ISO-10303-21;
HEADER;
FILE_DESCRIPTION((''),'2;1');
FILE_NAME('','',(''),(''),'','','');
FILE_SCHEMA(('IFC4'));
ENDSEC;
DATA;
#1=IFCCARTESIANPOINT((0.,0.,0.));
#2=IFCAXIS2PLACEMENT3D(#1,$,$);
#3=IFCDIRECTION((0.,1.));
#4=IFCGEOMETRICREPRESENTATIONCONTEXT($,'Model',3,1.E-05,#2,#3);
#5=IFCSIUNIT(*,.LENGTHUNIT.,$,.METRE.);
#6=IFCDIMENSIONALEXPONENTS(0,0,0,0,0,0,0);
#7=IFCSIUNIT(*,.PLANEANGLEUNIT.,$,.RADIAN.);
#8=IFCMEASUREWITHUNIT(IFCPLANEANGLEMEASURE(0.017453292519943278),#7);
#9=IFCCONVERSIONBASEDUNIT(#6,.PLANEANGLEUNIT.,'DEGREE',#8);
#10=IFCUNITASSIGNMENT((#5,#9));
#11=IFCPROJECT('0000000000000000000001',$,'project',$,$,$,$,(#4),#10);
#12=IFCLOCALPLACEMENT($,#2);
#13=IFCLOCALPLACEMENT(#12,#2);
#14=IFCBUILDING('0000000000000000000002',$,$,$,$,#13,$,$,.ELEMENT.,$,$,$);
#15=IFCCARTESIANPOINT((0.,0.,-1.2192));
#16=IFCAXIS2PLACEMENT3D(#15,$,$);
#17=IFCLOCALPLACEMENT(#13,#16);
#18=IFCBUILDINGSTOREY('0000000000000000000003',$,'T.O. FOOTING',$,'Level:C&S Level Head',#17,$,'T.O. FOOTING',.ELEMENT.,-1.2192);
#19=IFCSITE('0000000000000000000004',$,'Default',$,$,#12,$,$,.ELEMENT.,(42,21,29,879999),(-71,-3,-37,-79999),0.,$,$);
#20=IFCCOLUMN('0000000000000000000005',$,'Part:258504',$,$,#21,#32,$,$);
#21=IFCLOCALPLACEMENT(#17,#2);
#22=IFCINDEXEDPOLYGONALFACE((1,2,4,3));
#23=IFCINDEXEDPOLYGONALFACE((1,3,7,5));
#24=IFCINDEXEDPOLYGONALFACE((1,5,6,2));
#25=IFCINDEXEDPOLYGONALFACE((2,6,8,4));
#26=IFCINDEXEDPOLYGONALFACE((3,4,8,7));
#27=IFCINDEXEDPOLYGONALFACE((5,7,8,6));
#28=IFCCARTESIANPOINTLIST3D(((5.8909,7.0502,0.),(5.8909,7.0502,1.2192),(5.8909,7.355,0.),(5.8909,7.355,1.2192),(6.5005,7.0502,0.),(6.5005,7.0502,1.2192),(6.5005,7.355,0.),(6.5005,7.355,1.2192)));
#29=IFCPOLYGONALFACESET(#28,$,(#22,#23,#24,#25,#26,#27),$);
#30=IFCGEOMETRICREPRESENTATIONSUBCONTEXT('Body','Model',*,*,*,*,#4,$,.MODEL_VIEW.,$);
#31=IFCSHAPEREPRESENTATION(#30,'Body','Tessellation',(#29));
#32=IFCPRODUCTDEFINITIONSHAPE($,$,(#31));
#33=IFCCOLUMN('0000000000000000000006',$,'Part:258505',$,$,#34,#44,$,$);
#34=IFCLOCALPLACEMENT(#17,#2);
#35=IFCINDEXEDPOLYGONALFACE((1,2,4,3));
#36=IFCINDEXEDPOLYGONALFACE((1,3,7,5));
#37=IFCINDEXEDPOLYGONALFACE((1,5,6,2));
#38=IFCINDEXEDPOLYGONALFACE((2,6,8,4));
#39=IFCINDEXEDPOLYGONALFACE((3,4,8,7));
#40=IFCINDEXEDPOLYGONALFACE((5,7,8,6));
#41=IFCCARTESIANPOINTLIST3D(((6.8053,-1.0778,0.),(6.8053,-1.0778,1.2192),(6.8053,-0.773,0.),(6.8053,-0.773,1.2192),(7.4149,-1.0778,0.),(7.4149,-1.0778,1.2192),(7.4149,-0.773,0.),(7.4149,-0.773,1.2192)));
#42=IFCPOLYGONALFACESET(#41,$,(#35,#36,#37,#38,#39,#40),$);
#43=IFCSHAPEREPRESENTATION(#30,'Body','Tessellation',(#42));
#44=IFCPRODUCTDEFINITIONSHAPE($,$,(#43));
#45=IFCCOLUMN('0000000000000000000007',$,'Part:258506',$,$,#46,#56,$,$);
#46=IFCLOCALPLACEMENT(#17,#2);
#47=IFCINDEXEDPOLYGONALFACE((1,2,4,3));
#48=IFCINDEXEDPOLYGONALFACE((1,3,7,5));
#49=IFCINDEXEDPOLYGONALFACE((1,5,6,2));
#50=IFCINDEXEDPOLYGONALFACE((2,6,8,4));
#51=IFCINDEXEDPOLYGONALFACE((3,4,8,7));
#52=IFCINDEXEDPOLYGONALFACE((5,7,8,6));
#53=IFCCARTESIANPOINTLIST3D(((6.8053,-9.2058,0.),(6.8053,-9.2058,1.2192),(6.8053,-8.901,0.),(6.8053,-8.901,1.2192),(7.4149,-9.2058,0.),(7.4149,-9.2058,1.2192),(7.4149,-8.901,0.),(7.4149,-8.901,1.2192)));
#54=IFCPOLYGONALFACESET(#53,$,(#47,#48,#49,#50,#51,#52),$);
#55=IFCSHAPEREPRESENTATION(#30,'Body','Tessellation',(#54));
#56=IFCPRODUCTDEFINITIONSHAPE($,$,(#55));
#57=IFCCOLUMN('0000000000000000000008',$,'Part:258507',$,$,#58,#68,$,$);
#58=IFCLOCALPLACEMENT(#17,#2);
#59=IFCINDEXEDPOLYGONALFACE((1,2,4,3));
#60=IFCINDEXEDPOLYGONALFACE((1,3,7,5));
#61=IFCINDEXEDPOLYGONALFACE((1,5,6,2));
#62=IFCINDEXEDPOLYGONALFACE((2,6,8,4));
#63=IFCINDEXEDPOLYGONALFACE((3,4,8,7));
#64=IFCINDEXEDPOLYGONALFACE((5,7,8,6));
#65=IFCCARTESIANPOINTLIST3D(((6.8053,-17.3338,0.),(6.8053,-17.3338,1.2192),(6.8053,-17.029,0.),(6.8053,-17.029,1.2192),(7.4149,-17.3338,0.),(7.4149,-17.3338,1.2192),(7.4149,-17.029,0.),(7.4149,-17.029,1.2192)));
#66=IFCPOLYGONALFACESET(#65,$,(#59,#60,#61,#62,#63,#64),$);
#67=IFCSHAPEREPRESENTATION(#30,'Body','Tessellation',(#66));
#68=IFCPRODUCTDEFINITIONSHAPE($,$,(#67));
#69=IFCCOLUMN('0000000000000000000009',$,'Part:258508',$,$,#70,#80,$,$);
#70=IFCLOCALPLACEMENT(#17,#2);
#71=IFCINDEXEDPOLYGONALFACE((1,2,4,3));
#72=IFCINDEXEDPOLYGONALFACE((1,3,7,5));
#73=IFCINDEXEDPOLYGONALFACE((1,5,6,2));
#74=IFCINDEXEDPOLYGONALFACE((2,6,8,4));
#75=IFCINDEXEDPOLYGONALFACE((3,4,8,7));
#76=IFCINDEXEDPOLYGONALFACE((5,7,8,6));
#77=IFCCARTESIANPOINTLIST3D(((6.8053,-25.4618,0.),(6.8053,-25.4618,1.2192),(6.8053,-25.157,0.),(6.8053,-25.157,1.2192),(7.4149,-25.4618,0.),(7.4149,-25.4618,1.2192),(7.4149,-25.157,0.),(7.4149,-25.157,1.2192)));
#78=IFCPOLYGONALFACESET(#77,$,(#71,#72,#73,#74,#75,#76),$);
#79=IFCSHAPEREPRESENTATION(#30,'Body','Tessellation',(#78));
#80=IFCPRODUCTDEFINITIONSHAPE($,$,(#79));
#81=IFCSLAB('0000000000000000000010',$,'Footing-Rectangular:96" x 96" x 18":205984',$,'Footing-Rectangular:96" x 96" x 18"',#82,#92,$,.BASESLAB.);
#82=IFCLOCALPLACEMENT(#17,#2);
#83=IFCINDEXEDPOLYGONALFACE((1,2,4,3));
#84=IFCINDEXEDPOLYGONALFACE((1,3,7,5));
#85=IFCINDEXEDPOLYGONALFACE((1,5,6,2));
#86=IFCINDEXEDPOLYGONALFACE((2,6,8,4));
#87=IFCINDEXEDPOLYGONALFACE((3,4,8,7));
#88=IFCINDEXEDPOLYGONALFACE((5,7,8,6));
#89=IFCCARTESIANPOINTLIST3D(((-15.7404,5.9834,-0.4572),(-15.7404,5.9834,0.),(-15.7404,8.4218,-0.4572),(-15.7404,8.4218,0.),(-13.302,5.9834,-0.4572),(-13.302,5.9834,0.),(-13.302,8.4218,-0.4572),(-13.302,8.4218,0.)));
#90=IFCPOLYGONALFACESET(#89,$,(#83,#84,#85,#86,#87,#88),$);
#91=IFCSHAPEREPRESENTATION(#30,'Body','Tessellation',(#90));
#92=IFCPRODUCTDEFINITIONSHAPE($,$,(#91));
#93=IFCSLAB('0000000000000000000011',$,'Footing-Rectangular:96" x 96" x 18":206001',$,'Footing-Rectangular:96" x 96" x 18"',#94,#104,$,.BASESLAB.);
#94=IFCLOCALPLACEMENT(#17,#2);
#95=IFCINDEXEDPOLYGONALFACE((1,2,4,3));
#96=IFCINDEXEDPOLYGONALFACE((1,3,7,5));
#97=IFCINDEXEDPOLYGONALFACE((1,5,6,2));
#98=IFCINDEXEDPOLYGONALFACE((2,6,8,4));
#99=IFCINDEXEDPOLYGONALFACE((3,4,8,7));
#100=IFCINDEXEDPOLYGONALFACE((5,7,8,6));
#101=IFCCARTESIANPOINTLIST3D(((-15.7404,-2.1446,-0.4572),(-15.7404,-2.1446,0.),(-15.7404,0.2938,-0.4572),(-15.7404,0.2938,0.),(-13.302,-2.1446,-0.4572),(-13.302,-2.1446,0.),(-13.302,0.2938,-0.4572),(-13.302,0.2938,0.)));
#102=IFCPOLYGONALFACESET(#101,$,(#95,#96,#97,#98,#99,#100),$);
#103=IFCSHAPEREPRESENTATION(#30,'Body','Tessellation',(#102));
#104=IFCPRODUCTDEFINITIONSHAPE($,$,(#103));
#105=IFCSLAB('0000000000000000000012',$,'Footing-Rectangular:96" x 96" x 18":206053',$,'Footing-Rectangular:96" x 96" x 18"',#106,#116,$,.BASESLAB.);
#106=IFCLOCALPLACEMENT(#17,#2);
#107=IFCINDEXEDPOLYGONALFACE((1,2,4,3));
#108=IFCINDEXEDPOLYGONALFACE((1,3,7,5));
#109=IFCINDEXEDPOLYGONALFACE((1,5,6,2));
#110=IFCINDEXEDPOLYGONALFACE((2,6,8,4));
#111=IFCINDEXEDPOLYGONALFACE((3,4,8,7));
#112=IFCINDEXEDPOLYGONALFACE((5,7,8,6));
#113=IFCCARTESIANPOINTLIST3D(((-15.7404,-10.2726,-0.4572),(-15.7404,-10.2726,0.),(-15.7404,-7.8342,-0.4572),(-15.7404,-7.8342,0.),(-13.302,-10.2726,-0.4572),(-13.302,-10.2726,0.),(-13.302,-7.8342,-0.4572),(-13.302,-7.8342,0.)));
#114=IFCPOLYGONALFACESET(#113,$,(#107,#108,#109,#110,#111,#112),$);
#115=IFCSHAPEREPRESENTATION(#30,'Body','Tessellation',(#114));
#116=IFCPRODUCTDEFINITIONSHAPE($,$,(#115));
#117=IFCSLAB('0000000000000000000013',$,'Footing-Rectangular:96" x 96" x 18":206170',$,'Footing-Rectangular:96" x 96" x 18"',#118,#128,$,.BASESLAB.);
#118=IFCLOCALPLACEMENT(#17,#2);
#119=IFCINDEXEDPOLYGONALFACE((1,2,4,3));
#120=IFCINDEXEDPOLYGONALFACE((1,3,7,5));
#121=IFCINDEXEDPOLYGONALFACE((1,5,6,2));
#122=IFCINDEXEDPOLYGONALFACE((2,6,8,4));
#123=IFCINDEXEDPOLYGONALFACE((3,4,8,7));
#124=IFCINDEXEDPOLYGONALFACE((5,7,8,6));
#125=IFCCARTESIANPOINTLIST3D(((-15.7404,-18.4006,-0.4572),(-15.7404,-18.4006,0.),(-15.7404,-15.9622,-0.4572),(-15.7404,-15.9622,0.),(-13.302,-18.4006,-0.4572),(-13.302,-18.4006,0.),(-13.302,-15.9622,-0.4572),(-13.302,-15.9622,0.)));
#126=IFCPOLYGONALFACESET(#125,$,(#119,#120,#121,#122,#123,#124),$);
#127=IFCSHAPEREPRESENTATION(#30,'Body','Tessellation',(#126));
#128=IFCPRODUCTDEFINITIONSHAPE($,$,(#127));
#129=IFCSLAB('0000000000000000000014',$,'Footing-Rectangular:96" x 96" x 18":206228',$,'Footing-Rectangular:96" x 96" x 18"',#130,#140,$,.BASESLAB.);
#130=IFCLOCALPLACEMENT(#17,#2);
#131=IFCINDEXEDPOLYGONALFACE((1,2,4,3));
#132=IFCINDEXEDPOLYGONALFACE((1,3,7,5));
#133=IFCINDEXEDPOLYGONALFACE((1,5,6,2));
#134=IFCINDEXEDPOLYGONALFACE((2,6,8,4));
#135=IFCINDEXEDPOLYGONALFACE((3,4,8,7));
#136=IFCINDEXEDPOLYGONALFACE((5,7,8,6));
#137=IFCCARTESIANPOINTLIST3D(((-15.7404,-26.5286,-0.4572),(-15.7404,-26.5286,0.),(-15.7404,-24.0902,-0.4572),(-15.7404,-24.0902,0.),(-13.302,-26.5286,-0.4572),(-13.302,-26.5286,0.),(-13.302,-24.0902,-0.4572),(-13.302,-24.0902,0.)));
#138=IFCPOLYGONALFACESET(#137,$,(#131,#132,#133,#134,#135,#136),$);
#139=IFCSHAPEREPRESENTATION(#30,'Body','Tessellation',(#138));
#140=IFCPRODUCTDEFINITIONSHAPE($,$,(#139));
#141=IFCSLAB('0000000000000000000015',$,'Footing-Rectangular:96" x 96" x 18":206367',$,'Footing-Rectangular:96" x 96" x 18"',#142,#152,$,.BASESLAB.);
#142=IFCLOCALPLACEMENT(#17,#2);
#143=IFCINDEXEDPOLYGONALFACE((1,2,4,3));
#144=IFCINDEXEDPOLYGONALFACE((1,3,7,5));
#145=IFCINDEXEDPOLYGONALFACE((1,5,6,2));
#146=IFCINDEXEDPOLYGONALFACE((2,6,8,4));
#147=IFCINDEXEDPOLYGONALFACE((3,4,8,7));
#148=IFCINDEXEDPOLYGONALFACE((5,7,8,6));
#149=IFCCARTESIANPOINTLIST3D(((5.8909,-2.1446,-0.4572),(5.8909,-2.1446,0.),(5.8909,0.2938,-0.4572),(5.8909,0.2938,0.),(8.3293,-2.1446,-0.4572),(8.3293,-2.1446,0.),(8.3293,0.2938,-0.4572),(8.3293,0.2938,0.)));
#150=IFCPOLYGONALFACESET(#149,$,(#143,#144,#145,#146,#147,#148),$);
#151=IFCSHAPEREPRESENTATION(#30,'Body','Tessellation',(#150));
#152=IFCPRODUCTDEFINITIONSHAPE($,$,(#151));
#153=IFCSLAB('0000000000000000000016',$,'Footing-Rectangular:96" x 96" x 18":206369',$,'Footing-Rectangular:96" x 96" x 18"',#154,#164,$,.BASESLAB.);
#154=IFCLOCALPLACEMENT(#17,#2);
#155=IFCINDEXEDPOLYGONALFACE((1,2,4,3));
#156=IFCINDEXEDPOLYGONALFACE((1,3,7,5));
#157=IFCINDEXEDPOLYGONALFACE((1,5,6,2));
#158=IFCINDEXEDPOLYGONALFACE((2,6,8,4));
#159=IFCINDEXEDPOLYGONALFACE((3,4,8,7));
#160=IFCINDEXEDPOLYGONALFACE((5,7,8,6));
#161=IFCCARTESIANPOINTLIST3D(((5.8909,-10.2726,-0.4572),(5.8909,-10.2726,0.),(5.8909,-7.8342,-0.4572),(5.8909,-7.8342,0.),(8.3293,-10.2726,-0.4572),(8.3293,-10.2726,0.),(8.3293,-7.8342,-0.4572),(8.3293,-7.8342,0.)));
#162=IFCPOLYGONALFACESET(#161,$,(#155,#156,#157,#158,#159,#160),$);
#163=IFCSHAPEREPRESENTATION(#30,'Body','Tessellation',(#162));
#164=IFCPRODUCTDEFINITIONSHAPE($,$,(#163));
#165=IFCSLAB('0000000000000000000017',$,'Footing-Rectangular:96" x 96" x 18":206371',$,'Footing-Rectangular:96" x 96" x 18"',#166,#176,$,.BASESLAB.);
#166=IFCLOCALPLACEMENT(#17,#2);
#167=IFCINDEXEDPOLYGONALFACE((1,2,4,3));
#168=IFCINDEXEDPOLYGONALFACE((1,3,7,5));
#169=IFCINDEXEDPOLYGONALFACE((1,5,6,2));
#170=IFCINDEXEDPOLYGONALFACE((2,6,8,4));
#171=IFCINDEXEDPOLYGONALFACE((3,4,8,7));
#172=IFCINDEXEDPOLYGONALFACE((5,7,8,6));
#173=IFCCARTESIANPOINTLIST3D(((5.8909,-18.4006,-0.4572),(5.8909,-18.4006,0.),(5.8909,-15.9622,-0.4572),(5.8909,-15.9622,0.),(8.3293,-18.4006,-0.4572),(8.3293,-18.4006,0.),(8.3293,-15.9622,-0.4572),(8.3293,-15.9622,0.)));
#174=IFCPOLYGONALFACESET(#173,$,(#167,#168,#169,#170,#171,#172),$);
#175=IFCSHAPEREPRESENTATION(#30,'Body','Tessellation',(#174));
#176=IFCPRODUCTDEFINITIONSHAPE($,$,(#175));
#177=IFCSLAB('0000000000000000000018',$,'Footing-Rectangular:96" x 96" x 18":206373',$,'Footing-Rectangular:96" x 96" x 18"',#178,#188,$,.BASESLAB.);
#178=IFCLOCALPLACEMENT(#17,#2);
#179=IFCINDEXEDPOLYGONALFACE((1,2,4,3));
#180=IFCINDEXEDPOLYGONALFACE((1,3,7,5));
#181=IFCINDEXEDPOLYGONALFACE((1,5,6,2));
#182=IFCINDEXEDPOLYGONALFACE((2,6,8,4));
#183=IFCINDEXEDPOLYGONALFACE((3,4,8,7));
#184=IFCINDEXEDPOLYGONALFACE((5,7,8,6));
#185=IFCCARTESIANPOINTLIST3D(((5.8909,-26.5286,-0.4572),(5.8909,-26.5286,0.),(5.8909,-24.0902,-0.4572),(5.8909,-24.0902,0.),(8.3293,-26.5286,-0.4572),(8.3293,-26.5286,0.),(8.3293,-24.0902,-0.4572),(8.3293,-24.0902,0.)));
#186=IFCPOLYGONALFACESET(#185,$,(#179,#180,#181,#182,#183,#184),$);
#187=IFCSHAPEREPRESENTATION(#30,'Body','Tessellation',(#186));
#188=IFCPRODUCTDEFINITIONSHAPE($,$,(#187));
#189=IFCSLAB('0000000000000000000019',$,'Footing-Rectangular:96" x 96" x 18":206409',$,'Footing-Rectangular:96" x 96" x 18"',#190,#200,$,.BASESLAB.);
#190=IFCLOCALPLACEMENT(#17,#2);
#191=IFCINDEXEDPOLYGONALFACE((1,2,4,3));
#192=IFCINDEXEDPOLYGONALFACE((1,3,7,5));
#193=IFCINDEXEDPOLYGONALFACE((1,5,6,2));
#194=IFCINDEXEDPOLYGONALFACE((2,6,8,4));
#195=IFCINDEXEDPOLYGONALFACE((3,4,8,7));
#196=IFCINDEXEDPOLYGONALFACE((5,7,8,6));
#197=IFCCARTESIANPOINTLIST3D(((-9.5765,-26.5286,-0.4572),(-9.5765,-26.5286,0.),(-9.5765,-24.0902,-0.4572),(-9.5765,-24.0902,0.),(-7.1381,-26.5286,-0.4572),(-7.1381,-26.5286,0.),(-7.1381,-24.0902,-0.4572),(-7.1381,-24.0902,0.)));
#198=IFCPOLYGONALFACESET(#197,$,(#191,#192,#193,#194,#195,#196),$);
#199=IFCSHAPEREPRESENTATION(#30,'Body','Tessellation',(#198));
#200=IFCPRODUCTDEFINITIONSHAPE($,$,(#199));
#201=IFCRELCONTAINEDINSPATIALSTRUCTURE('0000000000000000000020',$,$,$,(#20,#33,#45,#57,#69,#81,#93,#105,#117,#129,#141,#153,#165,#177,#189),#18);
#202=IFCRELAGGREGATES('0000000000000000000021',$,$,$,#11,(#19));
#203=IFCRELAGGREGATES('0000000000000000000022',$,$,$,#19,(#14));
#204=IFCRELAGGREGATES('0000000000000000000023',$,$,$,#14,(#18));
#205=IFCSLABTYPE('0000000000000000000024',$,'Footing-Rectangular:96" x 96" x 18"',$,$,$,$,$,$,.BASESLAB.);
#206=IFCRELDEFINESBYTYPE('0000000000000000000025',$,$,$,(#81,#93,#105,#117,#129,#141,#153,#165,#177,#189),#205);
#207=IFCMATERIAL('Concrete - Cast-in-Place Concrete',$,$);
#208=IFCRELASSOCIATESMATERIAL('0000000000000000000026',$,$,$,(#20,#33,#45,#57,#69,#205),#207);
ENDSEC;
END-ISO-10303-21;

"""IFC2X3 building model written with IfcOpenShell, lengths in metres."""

from ifc_helpers import new_model, entity, si_unit, converted_unit, direction, frame, frame_2d, origin, origin_2d_with_axis, place, context, subcontext, project, spatial, rectangle, extrude, material, type_object, element, save


model = new_model("IFC2X3")

# Units and contexts
model_context = context("Model", 3, precision=1e-05, world=origin(), true_north=direction((0.0, 1.0)))
body_context = subcontext(model_context, "Body", "Model", "MODEL_VIEW")
ifc_project = project(units=[si_unit("LENGTHUNIT", "METRE"), converted_unit("PLANEANGLEUNIT", "DEGREE", entity("IfcPlaneAngleMeasure", 0.017453292519943278), si_unit("PLANEANGLEUNIT", "RADIAN"), dimensions=[0, 0, 0, 0, 0, 0, 0])], contexts=[model_context])

# Site, building, storey
site_placement = place(None, origin())
site = spatial("IfcSite", under=ifc_project, at=site_placement, Name="Default", CompositionType="ELEMENT", RefLatitude=(42, 21, 29, 879999), RefLongitude=(-71, -3, -37, -79999), RefElevation=0.0)
building_placement = place(site_placement, origin())
building = spatial("IfcBuilding", under=site, at=building_placement, CompositionType="ELEMENT")
storey_placement = place(building_placement, frame((0.0, 0.0, -1.2192)))
storey = spatial("IfcBuildingStorey", under=building, at=storey_placement, Name="T.O. FOOTING", ObjectType="Level:C&S Level Head", LongName="T.O. FOOTING", CompositionType="ELEMENT", Elevation=-1.2192)

# Columns
ifc_material = material(Name="Concrete - Cast-in-Place Concrete")
column_1_placement = place(storey_placement, origin())
element("IfcColumn", 1, at=column_1_placement, inside=storey, material=ifc_material, Name="Part:258504", context=body_context, shape_type="SweptSolid", body=[
    extrude(rectangle(XDim=1.2192, YDim=0.3048, at=origin_2d_with_axis()), frame((5.8909, 7.2026, 0.6096), z_axis=(1.0, 0.0, 0.0), x_axis=(0.0, 0.0, -1.0)), (0.0, 0.0, 1.0), 0.6096),
])
column_2_placement = place(storey_placement, origin())
element("IfcColumn", 2, at=column_2_placement, inside=storey, material=ifc_material, Name="Part:258505", context=body_context, shape_type="SweptSolid", body=[
    extrude(rectangle(XDim=1.2192, YDim=0.3048, at=origin_2d_with_axis()), frame((6.8053, -0.9254, 0.6096), z_axis=(1.0, 0.0, 0.0), x_axis=(0.0, 0.0, -1.0)), (0.0, 0.0, 1.0), 0.6096),
])
column_3_placement = place(storey_placement, origin())
element("IfcColumn", 3, at=column_3_placement, inside=storey, material=ifc_material, Name="Part:258506", context=body_context, shape_type="SweptSolid", body=[
    extrude(rectangle(XDim=1.2192, YDim=0.3048, at=origin_2d_with_axis()), frame((6.8053, -9.0534, 0.6096), z_axis=(1.0, 0.0, 0.0), x_axis=(0.0, 0.0, -1.0)), (0.0, 0.0, 1.0), 0.6096),
])
column_4_placement = place(storey_placement, origin())
element("IfcColumn", 4, at=column_4_placement, inside=storey, material=ifc_material, Name="Part:258507", context=body_context, shape_type="SweptSolid", body=[
    extrude(rectangle(XDim=1.2192, YDim=0.3048, at=origin_2d_with_axis()), frame((6.8053, -17.1814, 0.6096), z_axis=(1.0, 0.0, 0.0), x_axis=(0.0, 0.0, -1.0)), (0.0, 0.0, 1.0), 0.6096),
])
column_5_placement = place(storey_placement, origin())
element("IfcColumn", 5, at=column_5_placement, inside=storey, material=ifc_material, Name="Part:258508", context=body_context, shape_type="SweptSolid", body=[
    extrude(rectangle(XDim=1.2192, YDim=0.3048, at=origin_2d_with_axis()), frame((6.8053, -25.3094, 0.6096), z_axis=(1.0, 0.0, 0.0), x_axis=(0.0, 0.0, -1.0)), (0.0, 0.0, 1.0), 0.6096),
])

# Slabs
slab_type_1 = type_object("IfcSlabType", Name="Footing-Rectangular:96\" x 96\" x 18\"", PredefinedType="BASESLAB", material=ifc_material)
slab_1_placement = place(storey_placement, origin())
element("IfcSlab", 6, at=slab_1_placement, inside=storey, type_object=slab_type_1, Name="Footing-Rectangular:96\" x 96\" x 18\":205984", ObjectType="Footing-Rectangular:96\" x 96\" x 18\"", PredefinedType="BASESLAB", context=body_context, shape_type="SweptSolid", body=[
    extrude(rectangle(XDim=2.4384, YDim=2.4384, at=origin_2d_with_axis()), frame((-14.5212, 7.2026, -0.4572), z_axis=(0.0, 0.0, 1.0), x_axis=(-1.0, 0.0, 0.0)), (0.0, 0.0, 1.0), 0.4572),
])
slab_2_placement = place(storey_placement, origin())
element("IfcSlab", 7, at=slab_2_placement, inside=storey, type_object=slab_type_1, Name="Footing-Rectangular:96\" x 96\" x 18\":206001", ObjectType="Footing-Rectangular:96\" x 96\" x 18\"", PredefinedType="BASESLAB", context=body_context, shape_type="SweptSolid", body=[
    extrude(rectangle(XDim=2.4384, YDim=2.4384, at=frame_2d((0.0, 0.0), x_axis=(1.0, 0.0))), frame((-14.5212, -0.9254, -0.4572), z_axis=(0.0, 0.0, 1.0), x_axis=(-1.0, 0.0, 0.0)), (0.0, 0.0, 1.0), 0.4572),
])
slab_3_placement = place(storey_placement, origin())
element("IfcSlab", 8, at=slab_3_placement, inside=storey, type_object=slab_type_1, Name="Footing-Rectangular:96\" x 96\" x 18\":206053", ObjectType="Footing-Rectangular:96\" x 96\" x 18\"", PredefinedType="BASESLAB", context=body_context, shape_type="SweptSolid", body=[
    extrude(rectangle(XDim=2.4384, YDim=2.4384, at=origin_2d_with_axis()), frame((-14.5212, -9.0534, -0.4572), z_axis=(0.0, 0.0, 1.0), x_axis=(-1.0, 0.0, 0.0)), (0.0, 0.0, 1.0), 0.4572),
])
slab_4_placement = place(storey_placement, origin())
element("IfcSlab", 9, at=slab_4_placement, inside=storey, type_object=slab_type_1, Name="Footing-Rectangular:96\" x 96\" x 18\":206170", ObjectType="Footing-Rectangular:96\" x 96\" x 18\"", PredefinedType="BASESLAB", context=body_context, shape_type="SweptSolid", body=[
    extrude(rectangle(XDim=2.4384, YDim=2.4384, at=origin_2d_with_axis()), frame((-14.5212, -17.1814, -0.4572), z_axis=(0.0, 0.0, 1.0), x_axis=(-1.0, 0.0, 0.0)), (0.0, 0.0, 1.0), 0.4572),
])
slab_5_placement = place(storey_placement, origin())
element("IfcSlab", 10, at=slab_5_placement, inside=storey, type_object=slab_type_1, Name="Footing-Rectangular:96\" x 96\" x 18\":206228", ObjectType="Footing-Rectangular:96\" x 96\" x 18\"", PredefinedType="BASESLAB", context=body_context, shape_type="SweptSolid", body=[
    extrude(rectangle(XDim=2.4384, YDim=2.4384, at=origin_2d_with_axis()), frame((-14.5212, -25.3094, -0.4572), z_axis=(0.0, 0.0, 1.0), x_axis=(-1.0, 0.0, 0.0)), (0.0, 0.0, 1.0), 0.4572),
])
slab_6_placement = place(storey_placement, origin())
element("IfcSlab", 11, at=slab_6_placement, inside=storey, type_object=slab_type_1, Name="Footing-Rectangular:96\" x 96\" x 18\":206367", ObjectType="Footing-Rectangular:96\" x 96\" x 18\"", PredefinedType="BASESLAB", context=body_context, shape_type="SweptSolid", body=[
    extrude(rectangle(XDim=2.4384, YDim=2.4384, at=frame_2d((0.0, 0.0), x_axis=(1.0, 0.0))), frame((7.1101, -0.9254, -0.4572), z_axis=(0.0, 0.0, 1.0), x_axis=(0.0, -1.0, 0.0)), (0.0, 0.0, 1.0), 0.4572),
])
slab_7_placement = place(storey_placement, origin())
element("IfcSlab", 12, at=slab_7_placement, inside=storey, type_object=slab_type_1, Name="Footing-Rectangular:96\" x 96\" x 18\":206369", ObjectType="Footing-Rectangular:96\" x 96\" x 18\"", PredefinedType="BASESLAB", context=body_context, shape_type="SweptSolid", body=[
    extrude(rectangle(XDim=2.4384, YDim=2.4384, at=origin_2d_with_axis()), frame((7.1101, -9.0534, -0.4572), z_axis=(0.0, 0.0, 1.0), x_axis=(0.0, -1.0, 0.0)), (0.0, 0.0, 1.0), 0.4572),
])
slab_8_placement = place(storey_placement, origin())
element("IfcSlab", 13, at=slab_8_placement, inside=storey, type_object=slab_type_1, Name="Footing-Rectangular:96\" x 96\" x 18\":206371", ObjectType="Footing-Rectangular:96\" x 96\" x 18\"", PredefinedType="BASESLAB", context=body_context, shape_type="SweptSolid", body=[
    extrude(rectangle(XDim=2.4384, YDim=2.4384, at=origin_2d_with_axis()), frame((7.1101, -17.1814, -0.4572), z_axis=(0.0, 0.0, 1.0), x_axis=(0.0, -1.0, 0.0)), (0.0, 0.0, 1.0), 0.4572),
])
slab_9_placement = place(storey_placement, origin())
element("IfcSlab", 14, at=slab_9_placement, inside=storey, type_object=slab_type_1, Name="Footing-Rectangular:96\" x 96\" x 18\":206373", ObjectType="Footing-Rectangular:96\" x 96\" x 18\"", PredefinedType="BASESLAB", context=body_context, shape_type="SweptSolid", body=[
    extrude(rectangle(XDim=2.4384, YDim=2.4384, at=origin_2d_with_axis()), frame((7.1101, -25.3094, -0.4572), z_axis=(0.0, 0.0, 1.0), x_axis=(0.0, -1.0, 0.0)), (0.0, 0.0, 1.0), 0.4572),
])
slab_10_placement = place(storey_placement, origin())
element("IfcSlab", 15, at=slab_10_placement, inside=storey, type_object=slab_type_1, Name="Footing-Rectangular:96\" x 96\" x 18\":206409", ObjectType="Footing-Rectangular:96\" x 96\" x 18\"", PredefinedType="BASESLAB", context=body_context, shape_type="SweptSolid", body=[
    extrude(rectangle(XDim=2.4384, YDim=2.4384, at=origin_2d_with_axis()), frame((-8.3573, -25.3094, -0.4572), z_axis=(0.0, 0.0, 1.0), x_axis=(-1.0, 0.0, 0.0)), (0.0, 0.0, 1.0), 0.4572),
])

save(model, "model.ifc")
